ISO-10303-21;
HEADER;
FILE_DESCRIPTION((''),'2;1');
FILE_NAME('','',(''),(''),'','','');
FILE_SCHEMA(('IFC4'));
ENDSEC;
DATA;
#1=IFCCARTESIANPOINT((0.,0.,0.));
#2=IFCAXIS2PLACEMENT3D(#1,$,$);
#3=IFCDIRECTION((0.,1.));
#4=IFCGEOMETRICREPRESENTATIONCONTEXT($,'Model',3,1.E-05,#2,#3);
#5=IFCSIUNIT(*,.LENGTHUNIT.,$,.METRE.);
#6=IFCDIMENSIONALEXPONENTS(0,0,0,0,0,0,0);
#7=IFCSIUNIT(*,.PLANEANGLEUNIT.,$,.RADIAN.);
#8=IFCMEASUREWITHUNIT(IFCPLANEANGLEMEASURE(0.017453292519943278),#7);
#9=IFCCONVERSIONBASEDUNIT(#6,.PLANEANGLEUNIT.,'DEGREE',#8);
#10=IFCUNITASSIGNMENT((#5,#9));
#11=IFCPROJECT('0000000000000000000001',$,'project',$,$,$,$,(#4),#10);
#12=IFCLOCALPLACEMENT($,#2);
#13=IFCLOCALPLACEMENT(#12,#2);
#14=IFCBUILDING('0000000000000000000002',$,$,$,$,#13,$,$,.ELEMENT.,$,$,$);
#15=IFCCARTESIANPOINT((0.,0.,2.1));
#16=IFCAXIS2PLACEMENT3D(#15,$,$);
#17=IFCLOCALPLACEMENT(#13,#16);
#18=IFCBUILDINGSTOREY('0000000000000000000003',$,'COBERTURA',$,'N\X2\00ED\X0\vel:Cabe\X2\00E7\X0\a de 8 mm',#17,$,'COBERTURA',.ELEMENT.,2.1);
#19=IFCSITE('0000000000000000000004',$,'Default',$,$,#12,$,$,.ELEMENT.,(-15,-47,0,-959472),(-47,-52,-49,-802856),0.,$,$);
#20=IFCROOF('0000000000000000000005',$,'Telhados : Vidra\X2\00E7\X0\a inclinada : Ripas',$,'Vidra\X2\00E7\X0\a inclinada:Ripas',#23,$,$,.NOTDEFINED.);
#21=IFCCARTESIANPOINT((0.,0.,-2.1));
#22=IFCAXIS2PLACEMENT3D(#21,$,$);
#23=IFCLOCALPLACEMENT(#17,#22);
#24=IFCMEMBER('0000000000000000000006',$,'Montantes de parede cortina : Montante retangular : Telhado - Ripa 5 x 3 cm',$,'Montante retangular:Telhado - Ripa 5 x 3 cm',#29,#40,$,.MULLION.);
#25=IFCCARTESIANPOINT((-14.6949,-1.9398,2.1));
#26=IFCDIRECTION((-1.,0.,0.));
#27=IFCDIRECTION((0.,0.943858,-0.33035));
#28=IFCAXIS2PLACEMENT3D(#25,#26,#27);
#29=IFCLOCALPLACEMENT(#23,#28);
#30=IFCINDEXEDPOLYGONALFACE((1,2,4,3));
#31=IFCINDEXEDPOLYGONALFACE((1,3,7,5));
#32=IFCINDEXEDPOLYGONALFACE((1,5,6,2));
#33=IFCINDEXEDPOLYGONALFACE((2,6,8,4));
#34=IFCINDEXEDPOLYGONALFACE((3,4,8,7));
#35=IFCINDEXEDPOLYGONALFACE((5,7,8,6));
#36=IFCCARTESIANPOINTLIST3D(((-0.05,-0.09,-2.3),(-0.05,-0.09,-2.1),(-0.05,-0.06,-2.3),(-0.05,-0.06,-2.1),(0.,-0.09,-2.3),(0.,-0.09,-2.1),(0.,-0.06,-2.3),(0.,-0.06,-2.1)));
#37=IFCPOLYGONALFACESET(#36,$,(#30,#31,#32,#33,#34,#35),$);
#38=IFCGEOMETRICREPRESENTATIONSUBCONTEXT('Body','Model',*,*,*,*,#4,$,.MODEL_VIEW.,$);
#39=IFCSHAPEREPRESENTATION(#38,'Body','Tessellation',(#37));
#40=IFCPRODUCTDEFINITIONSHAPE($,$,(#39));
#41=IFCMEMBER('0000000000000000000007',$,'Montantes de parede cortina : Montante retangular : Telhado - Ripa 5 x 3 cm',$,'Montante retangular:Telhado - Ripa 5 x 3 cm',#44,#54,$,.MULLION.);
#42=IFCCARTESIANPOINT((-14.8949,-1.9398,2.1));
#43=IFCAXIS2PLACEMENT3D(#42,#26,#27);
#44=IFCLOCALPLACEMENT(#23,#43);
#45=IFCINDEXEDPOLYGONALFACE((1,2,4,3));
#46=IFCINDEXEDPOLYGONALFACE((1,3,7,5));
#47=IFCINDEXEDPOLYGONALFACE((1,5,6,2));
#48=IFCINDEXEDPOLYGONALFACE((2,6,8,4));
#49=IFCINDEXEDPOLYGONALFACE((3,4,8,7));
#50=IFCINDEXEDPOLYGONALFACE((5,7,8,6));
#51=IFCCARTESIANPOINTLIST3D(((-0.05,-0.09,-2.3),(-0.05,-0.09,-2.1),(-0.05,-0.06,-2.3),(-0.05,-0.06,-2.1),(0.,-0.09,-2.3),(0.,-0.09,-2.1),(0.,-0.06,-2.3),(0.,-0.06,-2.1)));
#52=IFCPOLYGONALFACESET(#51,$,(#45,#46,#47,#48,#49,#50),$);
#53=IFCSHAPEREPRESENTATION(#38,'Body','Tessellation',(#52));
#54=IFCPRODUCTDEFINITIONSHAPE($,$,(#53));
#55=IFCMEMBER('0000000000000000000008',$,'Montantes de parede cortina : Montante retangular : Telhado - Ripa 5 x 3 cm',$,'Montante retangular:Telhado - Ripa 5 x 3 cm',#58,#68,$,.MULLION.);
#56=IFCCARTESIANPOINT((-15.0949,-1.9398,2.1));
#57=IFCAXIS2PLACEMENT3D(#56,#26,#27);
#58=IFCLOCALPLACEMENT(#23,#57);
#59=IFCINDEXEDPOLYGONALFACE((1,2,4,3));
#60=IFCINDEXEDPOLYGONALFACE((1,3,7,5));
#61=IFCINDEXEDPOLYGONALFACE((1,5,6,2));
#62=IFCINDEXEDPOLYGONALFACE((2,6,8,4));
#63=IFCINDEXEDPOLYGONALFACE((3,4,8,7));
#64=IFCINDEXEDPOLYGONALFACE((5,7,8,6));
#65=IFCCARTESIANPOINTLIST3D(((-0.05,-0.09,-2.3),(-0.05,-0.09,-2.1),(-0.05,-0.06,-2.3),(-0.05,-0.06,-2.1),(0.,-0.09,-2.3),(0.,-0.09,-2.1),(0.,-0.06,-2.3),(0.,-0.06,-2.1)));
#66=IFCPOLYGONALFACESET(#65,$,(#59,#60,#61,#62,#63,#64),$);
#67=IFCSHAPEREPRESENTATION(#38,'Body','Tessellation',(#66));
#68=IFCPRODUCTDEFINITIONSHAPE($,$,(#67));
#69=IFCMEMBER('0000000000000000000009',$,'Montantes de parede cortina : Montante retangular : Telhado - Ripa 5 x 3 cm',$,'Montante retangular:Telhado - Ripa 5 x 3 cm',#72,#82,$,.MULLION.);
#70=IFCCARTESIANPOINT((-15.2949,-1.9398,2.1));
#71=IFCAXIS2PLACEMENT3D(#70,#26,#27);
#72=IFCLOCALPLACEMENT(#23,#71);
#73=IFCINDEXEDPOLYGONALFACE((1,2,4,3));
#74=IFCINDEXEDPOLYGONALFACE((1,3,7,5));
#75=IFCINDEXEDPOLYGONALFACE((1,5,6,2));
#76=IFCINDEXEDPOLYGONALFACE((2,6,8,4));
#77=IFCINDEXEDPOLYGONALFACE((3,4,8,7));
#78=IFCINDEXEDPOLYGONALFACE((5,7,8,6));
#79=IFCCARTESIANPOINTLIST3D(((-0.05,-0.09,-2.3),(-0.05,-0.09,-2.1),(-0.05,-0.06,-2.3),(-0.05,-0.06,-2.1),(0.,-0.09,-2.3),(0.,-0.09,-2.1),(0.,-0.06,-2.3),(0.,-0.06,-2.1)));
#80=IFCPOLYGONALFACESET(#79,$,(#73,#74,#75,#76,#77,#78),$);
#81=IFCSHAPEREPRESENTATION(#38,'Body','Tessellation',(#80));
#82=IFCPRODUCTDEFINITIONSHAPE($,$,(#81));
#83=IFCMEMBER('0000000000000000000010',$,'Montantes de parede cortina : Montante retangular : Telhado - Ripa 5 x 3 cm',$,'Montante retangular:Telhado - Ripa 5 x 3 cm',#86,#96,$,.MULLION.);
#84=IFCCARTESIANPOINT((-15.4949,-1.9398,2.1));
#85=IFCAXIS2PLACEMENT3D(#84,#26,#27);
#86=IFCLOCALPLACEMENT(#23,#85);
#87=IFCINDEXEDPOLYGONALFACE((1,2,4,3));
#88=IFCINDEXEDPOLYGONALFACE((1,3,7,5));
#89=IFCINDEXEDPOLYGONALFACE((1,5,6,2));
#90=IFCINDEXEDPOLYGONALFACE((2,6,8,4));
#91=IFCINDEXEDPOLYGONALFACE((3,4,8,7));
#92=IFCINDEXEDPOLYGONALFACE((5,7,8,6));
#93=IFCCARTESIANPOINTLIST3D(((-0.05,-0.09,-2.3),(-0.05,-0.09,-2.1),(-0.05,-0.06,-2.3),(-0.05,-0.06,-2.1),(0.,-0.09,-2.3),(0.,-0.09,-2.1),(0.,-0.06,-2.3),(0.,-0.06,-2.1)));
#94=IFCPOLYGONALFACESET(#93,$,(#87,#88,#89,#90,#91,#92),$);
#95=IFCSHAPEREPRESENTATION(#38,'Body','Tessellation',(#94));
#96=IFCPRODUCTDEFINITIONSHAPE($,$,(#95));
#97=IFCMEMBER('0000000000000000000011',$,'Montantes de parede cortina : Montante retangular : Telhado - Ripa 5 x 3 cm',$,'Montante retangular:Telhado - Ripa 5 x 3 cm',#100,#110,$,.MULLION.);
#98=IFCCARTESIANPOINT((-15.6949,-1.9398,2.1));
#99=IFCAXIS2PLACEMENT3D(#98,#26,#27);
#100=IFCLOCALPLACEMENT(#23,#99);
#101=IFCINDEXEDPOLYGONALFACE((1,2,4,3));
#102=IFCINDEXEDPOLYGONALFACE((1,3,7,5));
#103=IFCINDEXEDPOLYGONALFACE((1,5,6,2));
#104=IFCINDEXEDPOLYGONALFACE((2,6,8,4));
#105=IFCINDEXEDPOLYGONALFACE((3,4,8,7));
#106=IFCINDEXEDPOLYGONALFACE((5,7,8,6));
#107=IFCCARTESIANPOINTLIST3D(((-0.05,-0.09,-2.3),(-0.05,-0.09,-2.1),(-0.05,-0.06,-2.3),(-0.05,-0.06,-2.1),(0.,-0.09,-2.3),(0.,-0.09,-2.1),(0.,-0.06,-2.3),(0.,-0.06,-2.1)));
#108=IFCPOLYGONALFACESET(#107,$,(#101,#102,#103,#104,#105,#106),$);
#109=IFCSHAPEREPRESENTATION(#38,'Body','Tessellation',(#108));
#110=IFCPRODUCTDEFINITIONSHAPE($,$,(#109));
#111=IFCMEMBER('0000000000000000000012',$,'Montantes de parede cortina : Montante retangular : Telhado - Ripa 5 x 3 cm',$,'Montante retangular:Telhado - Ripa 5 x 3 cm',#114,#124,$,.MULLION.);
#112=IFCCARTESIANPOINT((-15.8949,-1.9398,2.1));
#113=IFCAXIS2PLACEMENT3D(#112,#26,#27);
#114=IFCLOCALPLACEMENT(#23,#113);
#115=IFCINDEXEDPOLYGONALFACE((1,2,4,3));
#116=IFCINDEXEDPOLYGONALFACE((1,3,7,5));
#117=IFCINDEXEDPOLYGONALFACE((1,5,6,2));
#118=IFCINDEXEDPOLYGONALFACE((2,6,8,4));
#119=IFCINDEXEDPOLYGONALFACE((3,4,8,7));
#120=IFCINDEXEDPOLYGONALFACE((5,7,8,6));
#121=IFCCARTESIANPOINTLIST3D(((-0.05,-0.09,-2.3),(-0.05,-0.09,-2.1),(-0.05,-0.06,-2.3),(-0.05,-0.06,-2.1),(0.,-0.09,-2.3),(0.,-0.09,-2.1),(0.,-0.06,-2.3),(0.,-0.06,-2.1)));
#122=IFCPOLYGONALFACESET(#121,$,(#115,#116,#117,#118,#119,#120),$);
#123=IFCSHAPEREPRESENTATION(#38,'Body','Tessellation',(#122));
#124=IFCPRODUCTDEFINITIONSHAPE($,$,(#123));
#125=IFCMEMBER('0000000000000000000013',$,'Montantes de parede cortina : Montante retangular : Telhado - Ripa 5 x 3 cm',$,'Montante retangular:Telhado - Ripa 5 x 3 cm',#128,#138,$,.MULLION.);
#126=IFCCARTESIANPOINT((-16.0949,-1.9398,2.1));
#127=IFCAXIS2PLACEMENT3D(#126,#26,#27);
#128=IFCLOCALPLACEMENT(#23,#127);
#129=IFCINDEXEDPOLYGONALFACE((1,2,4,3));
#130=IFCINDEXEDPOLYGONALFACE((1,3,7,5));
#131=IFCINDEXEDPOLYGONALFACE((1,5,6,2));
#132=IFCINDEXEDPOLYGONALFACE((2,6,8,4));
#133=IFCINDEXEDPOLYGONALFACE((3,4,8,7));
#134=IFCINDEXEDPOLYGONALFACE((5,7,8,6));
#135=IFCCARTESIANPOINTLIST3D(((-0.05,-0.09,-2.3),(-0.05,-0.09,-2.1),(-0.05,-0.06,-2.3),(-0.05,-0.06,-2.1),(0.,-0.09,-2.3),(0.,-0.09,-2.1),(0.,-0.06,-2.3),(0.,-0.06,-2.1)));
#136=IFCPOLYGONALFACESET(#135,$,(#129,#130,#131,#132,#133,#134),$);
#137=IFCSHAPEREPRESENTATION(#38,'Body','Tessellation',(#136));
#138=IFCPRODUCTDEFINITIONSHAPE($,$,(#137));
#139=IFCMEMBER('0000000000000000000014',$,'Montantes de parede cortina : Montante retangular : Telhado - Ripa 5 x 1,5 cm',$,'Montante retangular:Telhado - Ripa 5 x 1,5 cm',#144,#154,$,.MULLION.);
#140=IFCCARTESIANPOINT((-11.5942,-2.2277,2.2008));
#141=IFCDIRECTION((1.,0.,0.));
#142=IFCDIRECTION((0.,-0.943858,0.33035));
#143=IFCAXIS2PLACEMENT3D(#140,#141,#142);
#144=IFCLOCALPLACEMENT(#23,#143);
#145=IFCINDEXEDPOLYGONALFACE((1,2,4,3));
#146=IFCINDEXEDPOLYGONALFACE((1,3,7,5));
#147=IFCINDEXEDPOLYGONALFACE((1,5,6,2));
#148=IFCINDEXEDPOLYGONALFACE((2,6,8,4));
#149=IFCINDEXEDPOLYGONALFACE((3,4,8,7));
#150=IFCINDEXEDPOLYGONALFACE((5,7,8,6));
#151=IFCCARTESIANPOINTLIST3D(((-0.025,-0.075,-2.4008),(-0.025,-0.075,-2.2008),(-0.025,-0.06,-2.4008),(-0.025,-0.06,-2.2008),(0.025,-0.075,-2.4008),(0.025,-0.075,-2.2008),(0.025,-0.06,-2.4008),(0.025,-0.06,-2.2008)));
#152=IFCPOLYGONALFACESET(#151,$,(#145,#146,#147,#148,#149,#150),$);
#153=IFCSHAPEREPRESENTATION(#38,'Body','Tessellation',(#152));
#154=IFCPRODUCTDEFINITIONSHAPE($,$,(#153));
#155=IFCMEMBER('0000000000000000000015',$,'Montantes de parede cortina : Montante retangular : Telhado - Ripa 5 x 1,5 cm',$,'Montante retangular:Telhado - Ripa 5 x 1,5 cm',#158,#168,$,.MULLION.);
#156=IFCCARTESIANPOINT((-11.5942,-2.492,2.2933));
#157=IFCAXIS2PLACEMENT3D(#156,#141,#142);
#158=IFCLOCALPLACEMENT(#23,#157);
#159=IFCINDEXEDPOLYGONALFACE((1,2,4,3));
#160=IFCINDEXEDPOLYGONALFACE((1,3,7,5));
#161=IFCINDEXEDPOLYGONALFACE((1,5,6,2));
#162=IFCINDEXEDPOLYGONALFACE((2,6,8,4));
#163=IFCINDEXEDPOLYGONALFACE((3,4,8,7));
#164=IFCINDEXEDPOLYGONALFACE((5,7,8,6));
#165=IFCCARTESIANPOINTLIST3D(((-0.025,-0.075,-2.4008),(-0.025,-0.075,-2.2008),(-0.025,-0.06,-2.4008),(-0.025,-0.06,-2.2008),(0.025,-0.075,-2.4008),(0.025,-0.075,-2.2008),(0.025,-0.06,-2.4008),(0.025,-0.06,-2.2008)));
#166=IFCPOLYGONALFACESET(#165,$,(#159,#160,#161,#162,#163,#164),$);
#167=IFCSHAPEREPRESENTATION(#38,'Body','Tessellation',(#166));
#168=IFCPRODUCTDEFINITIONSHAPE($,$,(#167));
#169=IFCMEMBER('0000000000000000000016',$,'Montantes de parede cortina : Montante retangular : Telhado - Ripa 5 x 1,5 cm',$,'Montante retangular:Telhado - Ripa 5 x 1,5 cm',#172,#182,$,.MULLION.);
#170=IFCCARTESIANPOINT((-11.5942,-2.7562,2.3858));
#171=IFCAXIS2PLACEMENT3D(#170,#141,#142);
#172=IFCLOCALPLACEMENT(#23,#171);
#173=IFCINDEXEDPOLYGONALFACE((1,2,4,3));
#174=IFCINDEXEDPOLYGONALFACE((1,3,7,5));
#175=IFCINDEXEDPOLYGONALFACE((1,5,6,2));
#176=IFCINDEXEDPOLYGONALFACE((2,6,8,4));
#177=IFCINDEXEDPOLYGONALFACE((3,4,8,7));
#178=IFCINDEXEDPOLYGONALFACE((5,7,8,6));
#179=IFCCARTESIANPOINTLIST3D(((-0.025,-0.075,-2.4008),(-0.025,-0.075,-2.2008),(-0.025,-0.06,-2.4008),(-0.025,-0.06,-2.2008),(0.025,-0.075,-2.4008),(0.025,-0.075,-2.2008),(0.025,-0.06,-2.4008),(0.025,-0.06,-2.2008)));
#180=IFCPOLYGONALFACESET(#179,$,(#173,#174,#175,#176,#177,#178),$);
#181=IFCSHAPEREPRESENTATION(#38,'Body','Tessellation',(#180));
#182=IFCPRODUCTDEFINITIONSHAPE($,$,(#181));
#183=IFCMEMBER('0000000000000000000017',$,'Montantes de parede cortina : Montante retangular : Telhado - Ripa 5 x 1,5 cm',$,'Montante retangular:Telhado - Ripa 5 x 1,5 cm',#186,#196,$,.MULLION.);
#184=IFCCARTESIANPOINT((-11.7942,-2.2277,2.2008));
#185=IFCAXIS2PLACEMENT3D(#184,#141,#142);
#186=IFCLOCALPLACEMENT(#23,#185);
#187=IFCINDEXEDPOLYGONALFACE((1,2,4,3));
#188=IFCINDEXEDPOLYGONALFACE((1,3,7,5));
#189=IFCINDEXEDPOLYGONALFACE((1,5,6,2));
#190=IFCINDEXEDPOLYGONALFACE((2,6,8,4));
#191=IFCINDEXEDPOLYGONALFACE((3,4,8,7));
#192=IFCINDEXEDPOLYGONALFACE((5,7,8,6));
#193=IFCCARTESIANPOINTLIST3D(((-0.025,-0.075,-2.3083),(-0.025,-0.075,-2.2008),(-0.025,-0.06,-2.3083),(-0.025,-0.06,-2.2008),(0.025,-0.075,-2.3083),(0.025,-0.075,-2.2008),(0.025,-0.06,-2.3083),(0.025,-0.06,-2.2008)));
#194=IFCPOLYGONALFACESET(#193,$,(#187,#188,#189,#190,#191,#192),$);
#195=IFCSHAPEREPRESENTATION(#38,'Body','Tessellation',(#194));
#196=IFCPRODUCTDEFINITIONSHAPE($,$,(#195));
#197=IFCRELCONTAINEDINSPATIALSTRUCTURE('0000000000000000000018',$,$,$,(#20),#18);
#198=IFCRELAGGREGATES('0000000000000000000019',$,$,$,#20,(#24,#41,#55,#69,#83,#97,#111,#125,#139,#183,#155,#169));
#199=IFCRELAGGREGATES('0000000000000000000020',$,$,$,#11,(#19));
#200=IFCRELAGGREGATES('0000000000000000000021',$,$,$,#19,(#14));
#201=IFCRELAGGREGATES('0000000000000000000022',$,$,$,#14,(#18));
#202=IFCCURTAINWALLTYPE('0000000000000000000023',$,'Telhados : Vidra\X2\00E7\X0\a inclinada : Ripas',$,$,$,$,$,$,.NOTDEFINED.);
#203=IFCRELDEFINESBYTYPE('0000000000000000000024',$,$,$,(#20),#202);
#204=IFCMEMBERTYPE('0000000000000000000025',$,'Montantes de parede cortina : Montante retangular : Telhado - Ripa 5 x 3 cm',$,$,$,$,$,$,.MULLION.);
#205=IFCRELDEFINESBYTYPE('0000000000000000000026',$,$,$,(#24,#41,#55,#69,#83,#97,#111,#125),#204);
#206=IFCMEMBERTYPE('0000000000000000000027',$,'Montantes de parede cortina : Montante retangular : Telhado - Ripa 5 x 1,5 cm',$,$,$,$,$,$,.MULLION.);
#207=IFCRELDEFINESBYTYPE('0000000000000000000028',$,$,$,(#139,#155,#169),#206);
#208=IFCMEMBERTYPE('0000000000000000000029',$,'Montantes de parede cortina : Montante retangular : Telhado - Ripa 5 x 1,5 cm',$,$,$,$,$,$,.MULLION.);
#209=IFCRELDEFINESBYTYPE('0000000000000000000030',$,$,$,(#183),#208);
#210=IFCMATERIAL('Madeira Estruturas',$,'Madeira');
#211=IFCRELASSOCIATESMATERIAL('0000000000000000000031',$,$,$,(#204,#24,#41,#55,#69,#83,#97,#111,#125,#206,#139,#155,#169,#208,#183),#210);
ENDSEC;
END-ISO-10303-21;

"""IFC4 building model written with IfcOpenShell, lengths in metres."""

from ifc_helpers import new_model, entity, si_unit, converted_unit, direction, frame, origin, place, context, subcontext, project, spatial, indexed_curve, outline, extrude, source, transform, mapped, material, type_object, type_shapes, element, aggregate, save


model = new_model("IFC4")

# Units and contexts
model_context = context("Model", 3, precision=1e-05, world=origin(), true_north=direction((0.0, 1.0)))
body_context = subcontext(model_context, "Body", "Model", "MODEL_VIEW")
ifc_project = project(units=[si_unit("LENGTHUNIT", "METRE"), converted_unit("PLANEANGLEUNIT", "DEGREE", entity("IfcPlaneAngleMeasure", 0.017453292519943278), si_unit("PLANEANGLEUNIT", "RADIAN"), dimensions=[0, 0, 0, 0, 0, 0, 0])], contexts=[model_context])

# Site, building, storey
site_placement = place(None, origin())
site = spatial("IfcSite", under=ifc_project, at=site_placement, Name="Default", CompositionType="ELEMENT", RefLatitude=(-15, -47, 0, -959472), RefLongitude=(-47, -52, -49, -802856), RefElevation=0.0)
building_placement = place(site_placement, origin())
building = spatial("IfcBuilding", under=site, at=building_placement, CompositionType="ELEMENT")
storey_placement = place(building_placement, frame((0.0, 0.0, 2.1)))
storey = spatial("IfcBuildingStorey", under=building, at=storey_placement, Name="COBERTURA", ObjectType="Nível:Cabeça de 8 mm", LongName="COBERTURA", CompositionType="ELEMENT", Elevation=2.1)

# Roof, members
curtain_wall_type_1 = type_object("IfcCurtainWallType", Name="Telhados : Vidraça inclinada : Ripas", PredefinedType="NOTDEFINED")
roof_1_placement = place(storey_placement, frame((0.0, 0.0, -2.1)))
roof_1 = element("IfcRoof", 1, at=roof_1_placement, inside=storey, type_object=curtain_wall_type_1, Name="Telhados : Vidraça inclinada : Ripas", ObjectType="Vidraça inclinada:Ripas", PredefinedType="NOTDEFINED")
ifc_material_1 = material(Name="Madeira Estruturas", Category="Madeira")
member_type_1 = type_object("IfcMemberType", Name="Montantes de parede cortina : Montante retangular : Telhado - Ripa 5 x 3 cm", PredefinedType="MULLION", material=ifc_material_1)
shared_shape_1 = source(origin(), body_context, "Body", "SweptSolid", [
    extrude(outline(indexed_curve([(-0.025, -0.015), (0.025, -0.015), (0.025, 0.015), (-0.025, 0.015), (-0.025, -0.015)], self_intersect=False)), frame((-0.025, -0.075, -2.3), z_axis=(0.0, 0.0, 1.0), x_axis=(-1.0, 0.0, 0.0)), (0.0, 0.0, 1.0), 0.2),
])
type_shapes(member_type_1, [shared_shape_1])
member_1_placement = place(roof_1_placement, frame((-14.6949, -1.9398, 2.1), z_axis=(-1.0, 0.0, 0.0), x_axis=(0.0, 0.943858, -0.33035)))
member_1 = element("IfcMember", 2, at=member_1_placement, type_object=member_type_1, material=ifc_material_1, Name="Montantes de parede cortina : Montante retangular : Telhado - Ripa 5 x 3 cm", ObjectType="Montante retangular:Telhado - Ripa 5 x 3 cm", PredefinedType="MULLION", context=body_context, shape_type="MappedRepresentation", body=[
    mapped(shared_shape_1, transform((0.0, 0.0, 0.0), scale=1.0)),
])
member_2_placement = place(roof_1_placement, frame((-14.8949, -1.9398, 2.1), z_axis=(-1.0, 0.0, 0.0), x_axis=(0.0, 0.943858, -0.33035)))
member_2 = element("IfcMember", 3, at=member_2_placement, type_object=member_type_1, material=ifc_material_1, Name="Montantes de parede cortina : Montante retangular : Telhado - Ripa 5 x 3 cm", ObjectType="Montante retangular:Telhado - Ripa 5 x 3 cm", PredefinedType="MULLION", context=body_context, shape_type="MappedRepresentation", body=[
    mapped(shared_shape_1, transform((0.0, 0.0, 0.0), scale=1.0)),
])
member_3_placement = place(roof_1_placement, frame((-15.0949, -1.9398, 2.1), z_axis=(-1.0, 0.0, 0.0), x_axis=(0.0, 0.943858, -0.33035)))
member_3 = element("IfcMember", 4, at=member_3_placement, type_object=member_type_1, material=ifc_material_1, Name="Montantes de parede cortina : Montante retangular : Telhado - Ripa 5 x 3 cm", ObjectType="Montante retangular:Telhado - Ripa 5 x 3 cm", PredefinedType="MULLION", context=body_context, shape_type="MappedRepresentation", body=[
    mapped(shared_shape_1, transform((0.0, 0.0, 0.0), scale=1.0)),
])
member_4_placement = place(roof_1_placement, frame((-15.2949, -1.9398, 2.1), z_axis=(-1.0, 0.0, 0.0), x_axis=(0.0, 0.943858, -0.33035)))
member_4 = element("IfcMember", 5, at=member_4_placement, type_object=member_type_1, material=ifc_material_1, Name="Montantes de parede cortina : Montante retangular : Telhado - Ripa 5 x 3 cm", ObjectType="Montante retangular:Telhado - Ripa 5 x 3 cm", PredefinedType="MULLION", context=body_context, shape_type="MappedRepresentation", body=[
    mapped(shared_shape_1, transform((0.0, 0.0, 0.0), scale=1.0)),
])
member_5_placement = place(roof_1_placement, frame((-15.4949, -1.9398, 2.1), z_axis=(-1.0, 0.0, 0.0), x_axis=(0.0, 0.943858, -0.33035)))
member_5 = element("IfcMember", 6, at=member_5_placement, type_object=member_type_1, material=ifc_material_1, Name="Montantes de parede cortina : Montante retangular : Telhado - Ripa 5 x 3 cm", ObjectType="Montante retangular:Telhado - Ripa 5 x 3 cm", PredefinedType="MULLION", context=body_context, shape_type="MappedRepresentation", body=[
    mapped(shared_shape_1, transform((0.0, 0.0, 0.0), scale=1.0)),
])
member_6_placement = place(roof_1_placement, frame((-15.6949, -1.9398, 2.1), z_axis=(-1.0, 0.0, 0.0), x_axis=(0.0, 0.943858, -0.33035)))
member_6 = element("IfcMember", 7, at=member_6_placement, type_object=member_type_1, material=ifc_material_1, Name="Montantes de parede cortina : Montante retangular : Telhado - Ripa 5 x 3 cm", ObjectType="Montante retangular:Telhado - Ripa 5 x 3 cm", PredefinedType="MULLION", context=body_context, shape_type="MappedRepresentation", body=[
    mapped(shared_shape_1, transform((0.0, 0.0, 0.0), scale=1.0)),
])
member_7_placement = place(roof_1_placement, frame((-15.8949, -1.9398, 2.1), z_axis=(-1.0, 0.0, 0.0), x_axis=(0.0, 0.943858, -0.33035)))
member_7 = element("IfcMember", 8, at=member_7_placement, type_object=member_type_1, material=ifc_material_1, Name="Montantes de parede cortina : Montante retangular : Telhado - Ripa 5 x 3 cm", ObjectType="Montante retangular:Telhado - Ripa 5 x 3 cm", PredefinedType="MULLION", context=body_context, shape_type="MappedRepresentation", body=[
    mapped(shared_shape_1, transform((0.0, 0.0, 0.0), scale=1.0)),
])
member_8_placement = place(roof_1_placement, frame((-16.0949, -1.9398, 2.1), z_axis=(-1.0, 0.0, 0.0), x_axis=(0.0, 0.943858, -0.33035)))
member_8 = element("IfcMember", 9, at=member_8_placement, type_object=member_type_1, material=ifc_material_1, Name="Montantes de parede cortina : Montante retangular : Telhado - Ripa 5 x 3 cm", ObjectType="Montante retangular:Telhado - Ripa 5 x 3 cm", PredefinedType="MULLION", context=body_context, shape_type="MappedRepresentation", body=[
    mapped(shared_shape_1, transform((0.0, 0.0, 0.0), scale=1.0)),
])
member_type_2 = type_object("IfcMemberType", Name="Montantes de parede cortina : Montante retangular : Telhado - Ripa 5 x 1,5 cm", PredefinedType="MULLION", material=ifc_material_1)
shared_shape_2 = source(origin(), body_context, "Body", "SweptSolid", [
    extrude(outline(indexed_curve([(-0.025, -0.0075), (0.025, -0.0075), (0.025, 0.0075), (-0.025, 0.0075), (-0.025, -0.0075)], self_intersect=False)), frame((0.0, -0.0675, -2.4008), z_axis=(0.0, 0.0, 1.0), x_axis=(-1.0, 0.0, 0.0)), (0.0, 0.0, 1.0), 0.2),
])
type_shapes(member_type_2, [shared_shape_2])
member_9_placement = place(roof_1_placement, frame((-11.5942, -2.2277, 2.2008), z_axis=(1.0, 0.0, 0.0), x_axis=(0.0, -0.943858, 0.33035)))
member_9 = element("IfcMember", 10, at=member_9_placement, type_object=member_type_2, material=ifc_material_1, Name="Montantes de parede cortina : Montante retangular : Telhado - Ripa 5 x 1,5 cm", ObjectType="Montante retangular:Telhado - Ripa 5 x 1,5 cm", PredefinedType="MULLION", context=body_context, shape_type="MappedRepresentation", body=[
    mapped(shared_shape_2, transform((0.0, 0.0, 0.0), scale=1.0)),
])
member_10_placement = place(roof_1_placement, frame((-11.5942, -2.492, 2.2933), z_axis=(1.0, 0.0, 0.0), x_axis=(0.0, -0.943858, 0.33035)))
member_10 = element("IfcMember", 11, at=member_10_placement, type_object=member_type_2, material=ifc_material_1, Name="Montantes de parede cortina : Montante retangular : Telhado - Ripa 5 x 1,5 cm", ObjectType="Montante retangular:Telhado - Ripa 5 x 1,5 cm", PredefinedType="MULLION", context=body_context, shape_type="MappedRepresentation", body=[
    mapped(shared_shape_2, transform((0.0, 0.0, 0.0), scale=1.0)),
])
member_11_placement = place(roof_1_placement, frame((-11.5942, -2.7562, 2.3858), z_axis=(1.0, 0.0, 0.0), x_axis=(0.0, -0.943858, 0.33035)))
member_11 = element("IfcMember", 12, at=member_11_placement, type_object=member_type_2, material=ifc_material_1, Name="Montantes de parede cortina : Montante retangular : Telhado - Ripa 5 x 1,5 cm", ObjectType="Montante retangular:Telhado - Ripa 5 x 1,5 cm", PredefinedType="MULLION", context=body_context, shape_type="MappedRepresentation", body=[
    mapped(shared_shape_2, transform((0.0, 0.0, 0.0), scale=1.0)),
])
member_type_3 = type_object("IfcMemberType", Name="Montantes de parede cortina : Montante retangular : Telhado - Ripa 5 x 1,5 cm", PredefinedType="MULLION", material=ifc_material_1)
shared_shape_3 = source(origin(), body_context, "Body", "SweptSolid", [
    extrude(outline(indexed_curve([(-0.025, -0.0075), (0.025, -0.0075), (0.025, 0.0075), (-0.025, 0.0075), (-0.025, -0.0075)], self_intersect=False)), frame((0.0, -0.0675, -2.3083), z_axis=(0.0, 0.0, 1.0), x_axis=(-1.0, 0.0, 0.0)), (0.0, 0.0, 1.0), 0.1075),
])
type_shapes(member_type_3, [shared_shape_3])
member_12_placement = place(roof_1_placement, frame((-11.7942, -2.2277, 2.2008), z_axis=(1.0, 0.0, 0.0), x_axis=(0.0, -0.943858, 0.33035)))
member_12 = element("IfcMember", 13, at=member_12_placement, type_object=member_type_3, material=ifc_material_1, Name="Montantes de parede cortina : Montante retangular : Telhado - Ripa 5 x 1,5 cm", ObjectType="Montante retangular:Telhado - Ripa 5 x 1,5 cm", PredefinedType="MULLION", context=body_context, shape_type="MappedRepresentation", body=[
    mapped(shared_shape_3, transform((0.0, 0.0, 0.0), scale=1.0)),
])
aggregate(roof_1, [member_1, member_2, member_3, member_4, member_5, member_6, member_7, member_8, member_9, member_12, member_10, member_11])

save(model, "model.ifc")
